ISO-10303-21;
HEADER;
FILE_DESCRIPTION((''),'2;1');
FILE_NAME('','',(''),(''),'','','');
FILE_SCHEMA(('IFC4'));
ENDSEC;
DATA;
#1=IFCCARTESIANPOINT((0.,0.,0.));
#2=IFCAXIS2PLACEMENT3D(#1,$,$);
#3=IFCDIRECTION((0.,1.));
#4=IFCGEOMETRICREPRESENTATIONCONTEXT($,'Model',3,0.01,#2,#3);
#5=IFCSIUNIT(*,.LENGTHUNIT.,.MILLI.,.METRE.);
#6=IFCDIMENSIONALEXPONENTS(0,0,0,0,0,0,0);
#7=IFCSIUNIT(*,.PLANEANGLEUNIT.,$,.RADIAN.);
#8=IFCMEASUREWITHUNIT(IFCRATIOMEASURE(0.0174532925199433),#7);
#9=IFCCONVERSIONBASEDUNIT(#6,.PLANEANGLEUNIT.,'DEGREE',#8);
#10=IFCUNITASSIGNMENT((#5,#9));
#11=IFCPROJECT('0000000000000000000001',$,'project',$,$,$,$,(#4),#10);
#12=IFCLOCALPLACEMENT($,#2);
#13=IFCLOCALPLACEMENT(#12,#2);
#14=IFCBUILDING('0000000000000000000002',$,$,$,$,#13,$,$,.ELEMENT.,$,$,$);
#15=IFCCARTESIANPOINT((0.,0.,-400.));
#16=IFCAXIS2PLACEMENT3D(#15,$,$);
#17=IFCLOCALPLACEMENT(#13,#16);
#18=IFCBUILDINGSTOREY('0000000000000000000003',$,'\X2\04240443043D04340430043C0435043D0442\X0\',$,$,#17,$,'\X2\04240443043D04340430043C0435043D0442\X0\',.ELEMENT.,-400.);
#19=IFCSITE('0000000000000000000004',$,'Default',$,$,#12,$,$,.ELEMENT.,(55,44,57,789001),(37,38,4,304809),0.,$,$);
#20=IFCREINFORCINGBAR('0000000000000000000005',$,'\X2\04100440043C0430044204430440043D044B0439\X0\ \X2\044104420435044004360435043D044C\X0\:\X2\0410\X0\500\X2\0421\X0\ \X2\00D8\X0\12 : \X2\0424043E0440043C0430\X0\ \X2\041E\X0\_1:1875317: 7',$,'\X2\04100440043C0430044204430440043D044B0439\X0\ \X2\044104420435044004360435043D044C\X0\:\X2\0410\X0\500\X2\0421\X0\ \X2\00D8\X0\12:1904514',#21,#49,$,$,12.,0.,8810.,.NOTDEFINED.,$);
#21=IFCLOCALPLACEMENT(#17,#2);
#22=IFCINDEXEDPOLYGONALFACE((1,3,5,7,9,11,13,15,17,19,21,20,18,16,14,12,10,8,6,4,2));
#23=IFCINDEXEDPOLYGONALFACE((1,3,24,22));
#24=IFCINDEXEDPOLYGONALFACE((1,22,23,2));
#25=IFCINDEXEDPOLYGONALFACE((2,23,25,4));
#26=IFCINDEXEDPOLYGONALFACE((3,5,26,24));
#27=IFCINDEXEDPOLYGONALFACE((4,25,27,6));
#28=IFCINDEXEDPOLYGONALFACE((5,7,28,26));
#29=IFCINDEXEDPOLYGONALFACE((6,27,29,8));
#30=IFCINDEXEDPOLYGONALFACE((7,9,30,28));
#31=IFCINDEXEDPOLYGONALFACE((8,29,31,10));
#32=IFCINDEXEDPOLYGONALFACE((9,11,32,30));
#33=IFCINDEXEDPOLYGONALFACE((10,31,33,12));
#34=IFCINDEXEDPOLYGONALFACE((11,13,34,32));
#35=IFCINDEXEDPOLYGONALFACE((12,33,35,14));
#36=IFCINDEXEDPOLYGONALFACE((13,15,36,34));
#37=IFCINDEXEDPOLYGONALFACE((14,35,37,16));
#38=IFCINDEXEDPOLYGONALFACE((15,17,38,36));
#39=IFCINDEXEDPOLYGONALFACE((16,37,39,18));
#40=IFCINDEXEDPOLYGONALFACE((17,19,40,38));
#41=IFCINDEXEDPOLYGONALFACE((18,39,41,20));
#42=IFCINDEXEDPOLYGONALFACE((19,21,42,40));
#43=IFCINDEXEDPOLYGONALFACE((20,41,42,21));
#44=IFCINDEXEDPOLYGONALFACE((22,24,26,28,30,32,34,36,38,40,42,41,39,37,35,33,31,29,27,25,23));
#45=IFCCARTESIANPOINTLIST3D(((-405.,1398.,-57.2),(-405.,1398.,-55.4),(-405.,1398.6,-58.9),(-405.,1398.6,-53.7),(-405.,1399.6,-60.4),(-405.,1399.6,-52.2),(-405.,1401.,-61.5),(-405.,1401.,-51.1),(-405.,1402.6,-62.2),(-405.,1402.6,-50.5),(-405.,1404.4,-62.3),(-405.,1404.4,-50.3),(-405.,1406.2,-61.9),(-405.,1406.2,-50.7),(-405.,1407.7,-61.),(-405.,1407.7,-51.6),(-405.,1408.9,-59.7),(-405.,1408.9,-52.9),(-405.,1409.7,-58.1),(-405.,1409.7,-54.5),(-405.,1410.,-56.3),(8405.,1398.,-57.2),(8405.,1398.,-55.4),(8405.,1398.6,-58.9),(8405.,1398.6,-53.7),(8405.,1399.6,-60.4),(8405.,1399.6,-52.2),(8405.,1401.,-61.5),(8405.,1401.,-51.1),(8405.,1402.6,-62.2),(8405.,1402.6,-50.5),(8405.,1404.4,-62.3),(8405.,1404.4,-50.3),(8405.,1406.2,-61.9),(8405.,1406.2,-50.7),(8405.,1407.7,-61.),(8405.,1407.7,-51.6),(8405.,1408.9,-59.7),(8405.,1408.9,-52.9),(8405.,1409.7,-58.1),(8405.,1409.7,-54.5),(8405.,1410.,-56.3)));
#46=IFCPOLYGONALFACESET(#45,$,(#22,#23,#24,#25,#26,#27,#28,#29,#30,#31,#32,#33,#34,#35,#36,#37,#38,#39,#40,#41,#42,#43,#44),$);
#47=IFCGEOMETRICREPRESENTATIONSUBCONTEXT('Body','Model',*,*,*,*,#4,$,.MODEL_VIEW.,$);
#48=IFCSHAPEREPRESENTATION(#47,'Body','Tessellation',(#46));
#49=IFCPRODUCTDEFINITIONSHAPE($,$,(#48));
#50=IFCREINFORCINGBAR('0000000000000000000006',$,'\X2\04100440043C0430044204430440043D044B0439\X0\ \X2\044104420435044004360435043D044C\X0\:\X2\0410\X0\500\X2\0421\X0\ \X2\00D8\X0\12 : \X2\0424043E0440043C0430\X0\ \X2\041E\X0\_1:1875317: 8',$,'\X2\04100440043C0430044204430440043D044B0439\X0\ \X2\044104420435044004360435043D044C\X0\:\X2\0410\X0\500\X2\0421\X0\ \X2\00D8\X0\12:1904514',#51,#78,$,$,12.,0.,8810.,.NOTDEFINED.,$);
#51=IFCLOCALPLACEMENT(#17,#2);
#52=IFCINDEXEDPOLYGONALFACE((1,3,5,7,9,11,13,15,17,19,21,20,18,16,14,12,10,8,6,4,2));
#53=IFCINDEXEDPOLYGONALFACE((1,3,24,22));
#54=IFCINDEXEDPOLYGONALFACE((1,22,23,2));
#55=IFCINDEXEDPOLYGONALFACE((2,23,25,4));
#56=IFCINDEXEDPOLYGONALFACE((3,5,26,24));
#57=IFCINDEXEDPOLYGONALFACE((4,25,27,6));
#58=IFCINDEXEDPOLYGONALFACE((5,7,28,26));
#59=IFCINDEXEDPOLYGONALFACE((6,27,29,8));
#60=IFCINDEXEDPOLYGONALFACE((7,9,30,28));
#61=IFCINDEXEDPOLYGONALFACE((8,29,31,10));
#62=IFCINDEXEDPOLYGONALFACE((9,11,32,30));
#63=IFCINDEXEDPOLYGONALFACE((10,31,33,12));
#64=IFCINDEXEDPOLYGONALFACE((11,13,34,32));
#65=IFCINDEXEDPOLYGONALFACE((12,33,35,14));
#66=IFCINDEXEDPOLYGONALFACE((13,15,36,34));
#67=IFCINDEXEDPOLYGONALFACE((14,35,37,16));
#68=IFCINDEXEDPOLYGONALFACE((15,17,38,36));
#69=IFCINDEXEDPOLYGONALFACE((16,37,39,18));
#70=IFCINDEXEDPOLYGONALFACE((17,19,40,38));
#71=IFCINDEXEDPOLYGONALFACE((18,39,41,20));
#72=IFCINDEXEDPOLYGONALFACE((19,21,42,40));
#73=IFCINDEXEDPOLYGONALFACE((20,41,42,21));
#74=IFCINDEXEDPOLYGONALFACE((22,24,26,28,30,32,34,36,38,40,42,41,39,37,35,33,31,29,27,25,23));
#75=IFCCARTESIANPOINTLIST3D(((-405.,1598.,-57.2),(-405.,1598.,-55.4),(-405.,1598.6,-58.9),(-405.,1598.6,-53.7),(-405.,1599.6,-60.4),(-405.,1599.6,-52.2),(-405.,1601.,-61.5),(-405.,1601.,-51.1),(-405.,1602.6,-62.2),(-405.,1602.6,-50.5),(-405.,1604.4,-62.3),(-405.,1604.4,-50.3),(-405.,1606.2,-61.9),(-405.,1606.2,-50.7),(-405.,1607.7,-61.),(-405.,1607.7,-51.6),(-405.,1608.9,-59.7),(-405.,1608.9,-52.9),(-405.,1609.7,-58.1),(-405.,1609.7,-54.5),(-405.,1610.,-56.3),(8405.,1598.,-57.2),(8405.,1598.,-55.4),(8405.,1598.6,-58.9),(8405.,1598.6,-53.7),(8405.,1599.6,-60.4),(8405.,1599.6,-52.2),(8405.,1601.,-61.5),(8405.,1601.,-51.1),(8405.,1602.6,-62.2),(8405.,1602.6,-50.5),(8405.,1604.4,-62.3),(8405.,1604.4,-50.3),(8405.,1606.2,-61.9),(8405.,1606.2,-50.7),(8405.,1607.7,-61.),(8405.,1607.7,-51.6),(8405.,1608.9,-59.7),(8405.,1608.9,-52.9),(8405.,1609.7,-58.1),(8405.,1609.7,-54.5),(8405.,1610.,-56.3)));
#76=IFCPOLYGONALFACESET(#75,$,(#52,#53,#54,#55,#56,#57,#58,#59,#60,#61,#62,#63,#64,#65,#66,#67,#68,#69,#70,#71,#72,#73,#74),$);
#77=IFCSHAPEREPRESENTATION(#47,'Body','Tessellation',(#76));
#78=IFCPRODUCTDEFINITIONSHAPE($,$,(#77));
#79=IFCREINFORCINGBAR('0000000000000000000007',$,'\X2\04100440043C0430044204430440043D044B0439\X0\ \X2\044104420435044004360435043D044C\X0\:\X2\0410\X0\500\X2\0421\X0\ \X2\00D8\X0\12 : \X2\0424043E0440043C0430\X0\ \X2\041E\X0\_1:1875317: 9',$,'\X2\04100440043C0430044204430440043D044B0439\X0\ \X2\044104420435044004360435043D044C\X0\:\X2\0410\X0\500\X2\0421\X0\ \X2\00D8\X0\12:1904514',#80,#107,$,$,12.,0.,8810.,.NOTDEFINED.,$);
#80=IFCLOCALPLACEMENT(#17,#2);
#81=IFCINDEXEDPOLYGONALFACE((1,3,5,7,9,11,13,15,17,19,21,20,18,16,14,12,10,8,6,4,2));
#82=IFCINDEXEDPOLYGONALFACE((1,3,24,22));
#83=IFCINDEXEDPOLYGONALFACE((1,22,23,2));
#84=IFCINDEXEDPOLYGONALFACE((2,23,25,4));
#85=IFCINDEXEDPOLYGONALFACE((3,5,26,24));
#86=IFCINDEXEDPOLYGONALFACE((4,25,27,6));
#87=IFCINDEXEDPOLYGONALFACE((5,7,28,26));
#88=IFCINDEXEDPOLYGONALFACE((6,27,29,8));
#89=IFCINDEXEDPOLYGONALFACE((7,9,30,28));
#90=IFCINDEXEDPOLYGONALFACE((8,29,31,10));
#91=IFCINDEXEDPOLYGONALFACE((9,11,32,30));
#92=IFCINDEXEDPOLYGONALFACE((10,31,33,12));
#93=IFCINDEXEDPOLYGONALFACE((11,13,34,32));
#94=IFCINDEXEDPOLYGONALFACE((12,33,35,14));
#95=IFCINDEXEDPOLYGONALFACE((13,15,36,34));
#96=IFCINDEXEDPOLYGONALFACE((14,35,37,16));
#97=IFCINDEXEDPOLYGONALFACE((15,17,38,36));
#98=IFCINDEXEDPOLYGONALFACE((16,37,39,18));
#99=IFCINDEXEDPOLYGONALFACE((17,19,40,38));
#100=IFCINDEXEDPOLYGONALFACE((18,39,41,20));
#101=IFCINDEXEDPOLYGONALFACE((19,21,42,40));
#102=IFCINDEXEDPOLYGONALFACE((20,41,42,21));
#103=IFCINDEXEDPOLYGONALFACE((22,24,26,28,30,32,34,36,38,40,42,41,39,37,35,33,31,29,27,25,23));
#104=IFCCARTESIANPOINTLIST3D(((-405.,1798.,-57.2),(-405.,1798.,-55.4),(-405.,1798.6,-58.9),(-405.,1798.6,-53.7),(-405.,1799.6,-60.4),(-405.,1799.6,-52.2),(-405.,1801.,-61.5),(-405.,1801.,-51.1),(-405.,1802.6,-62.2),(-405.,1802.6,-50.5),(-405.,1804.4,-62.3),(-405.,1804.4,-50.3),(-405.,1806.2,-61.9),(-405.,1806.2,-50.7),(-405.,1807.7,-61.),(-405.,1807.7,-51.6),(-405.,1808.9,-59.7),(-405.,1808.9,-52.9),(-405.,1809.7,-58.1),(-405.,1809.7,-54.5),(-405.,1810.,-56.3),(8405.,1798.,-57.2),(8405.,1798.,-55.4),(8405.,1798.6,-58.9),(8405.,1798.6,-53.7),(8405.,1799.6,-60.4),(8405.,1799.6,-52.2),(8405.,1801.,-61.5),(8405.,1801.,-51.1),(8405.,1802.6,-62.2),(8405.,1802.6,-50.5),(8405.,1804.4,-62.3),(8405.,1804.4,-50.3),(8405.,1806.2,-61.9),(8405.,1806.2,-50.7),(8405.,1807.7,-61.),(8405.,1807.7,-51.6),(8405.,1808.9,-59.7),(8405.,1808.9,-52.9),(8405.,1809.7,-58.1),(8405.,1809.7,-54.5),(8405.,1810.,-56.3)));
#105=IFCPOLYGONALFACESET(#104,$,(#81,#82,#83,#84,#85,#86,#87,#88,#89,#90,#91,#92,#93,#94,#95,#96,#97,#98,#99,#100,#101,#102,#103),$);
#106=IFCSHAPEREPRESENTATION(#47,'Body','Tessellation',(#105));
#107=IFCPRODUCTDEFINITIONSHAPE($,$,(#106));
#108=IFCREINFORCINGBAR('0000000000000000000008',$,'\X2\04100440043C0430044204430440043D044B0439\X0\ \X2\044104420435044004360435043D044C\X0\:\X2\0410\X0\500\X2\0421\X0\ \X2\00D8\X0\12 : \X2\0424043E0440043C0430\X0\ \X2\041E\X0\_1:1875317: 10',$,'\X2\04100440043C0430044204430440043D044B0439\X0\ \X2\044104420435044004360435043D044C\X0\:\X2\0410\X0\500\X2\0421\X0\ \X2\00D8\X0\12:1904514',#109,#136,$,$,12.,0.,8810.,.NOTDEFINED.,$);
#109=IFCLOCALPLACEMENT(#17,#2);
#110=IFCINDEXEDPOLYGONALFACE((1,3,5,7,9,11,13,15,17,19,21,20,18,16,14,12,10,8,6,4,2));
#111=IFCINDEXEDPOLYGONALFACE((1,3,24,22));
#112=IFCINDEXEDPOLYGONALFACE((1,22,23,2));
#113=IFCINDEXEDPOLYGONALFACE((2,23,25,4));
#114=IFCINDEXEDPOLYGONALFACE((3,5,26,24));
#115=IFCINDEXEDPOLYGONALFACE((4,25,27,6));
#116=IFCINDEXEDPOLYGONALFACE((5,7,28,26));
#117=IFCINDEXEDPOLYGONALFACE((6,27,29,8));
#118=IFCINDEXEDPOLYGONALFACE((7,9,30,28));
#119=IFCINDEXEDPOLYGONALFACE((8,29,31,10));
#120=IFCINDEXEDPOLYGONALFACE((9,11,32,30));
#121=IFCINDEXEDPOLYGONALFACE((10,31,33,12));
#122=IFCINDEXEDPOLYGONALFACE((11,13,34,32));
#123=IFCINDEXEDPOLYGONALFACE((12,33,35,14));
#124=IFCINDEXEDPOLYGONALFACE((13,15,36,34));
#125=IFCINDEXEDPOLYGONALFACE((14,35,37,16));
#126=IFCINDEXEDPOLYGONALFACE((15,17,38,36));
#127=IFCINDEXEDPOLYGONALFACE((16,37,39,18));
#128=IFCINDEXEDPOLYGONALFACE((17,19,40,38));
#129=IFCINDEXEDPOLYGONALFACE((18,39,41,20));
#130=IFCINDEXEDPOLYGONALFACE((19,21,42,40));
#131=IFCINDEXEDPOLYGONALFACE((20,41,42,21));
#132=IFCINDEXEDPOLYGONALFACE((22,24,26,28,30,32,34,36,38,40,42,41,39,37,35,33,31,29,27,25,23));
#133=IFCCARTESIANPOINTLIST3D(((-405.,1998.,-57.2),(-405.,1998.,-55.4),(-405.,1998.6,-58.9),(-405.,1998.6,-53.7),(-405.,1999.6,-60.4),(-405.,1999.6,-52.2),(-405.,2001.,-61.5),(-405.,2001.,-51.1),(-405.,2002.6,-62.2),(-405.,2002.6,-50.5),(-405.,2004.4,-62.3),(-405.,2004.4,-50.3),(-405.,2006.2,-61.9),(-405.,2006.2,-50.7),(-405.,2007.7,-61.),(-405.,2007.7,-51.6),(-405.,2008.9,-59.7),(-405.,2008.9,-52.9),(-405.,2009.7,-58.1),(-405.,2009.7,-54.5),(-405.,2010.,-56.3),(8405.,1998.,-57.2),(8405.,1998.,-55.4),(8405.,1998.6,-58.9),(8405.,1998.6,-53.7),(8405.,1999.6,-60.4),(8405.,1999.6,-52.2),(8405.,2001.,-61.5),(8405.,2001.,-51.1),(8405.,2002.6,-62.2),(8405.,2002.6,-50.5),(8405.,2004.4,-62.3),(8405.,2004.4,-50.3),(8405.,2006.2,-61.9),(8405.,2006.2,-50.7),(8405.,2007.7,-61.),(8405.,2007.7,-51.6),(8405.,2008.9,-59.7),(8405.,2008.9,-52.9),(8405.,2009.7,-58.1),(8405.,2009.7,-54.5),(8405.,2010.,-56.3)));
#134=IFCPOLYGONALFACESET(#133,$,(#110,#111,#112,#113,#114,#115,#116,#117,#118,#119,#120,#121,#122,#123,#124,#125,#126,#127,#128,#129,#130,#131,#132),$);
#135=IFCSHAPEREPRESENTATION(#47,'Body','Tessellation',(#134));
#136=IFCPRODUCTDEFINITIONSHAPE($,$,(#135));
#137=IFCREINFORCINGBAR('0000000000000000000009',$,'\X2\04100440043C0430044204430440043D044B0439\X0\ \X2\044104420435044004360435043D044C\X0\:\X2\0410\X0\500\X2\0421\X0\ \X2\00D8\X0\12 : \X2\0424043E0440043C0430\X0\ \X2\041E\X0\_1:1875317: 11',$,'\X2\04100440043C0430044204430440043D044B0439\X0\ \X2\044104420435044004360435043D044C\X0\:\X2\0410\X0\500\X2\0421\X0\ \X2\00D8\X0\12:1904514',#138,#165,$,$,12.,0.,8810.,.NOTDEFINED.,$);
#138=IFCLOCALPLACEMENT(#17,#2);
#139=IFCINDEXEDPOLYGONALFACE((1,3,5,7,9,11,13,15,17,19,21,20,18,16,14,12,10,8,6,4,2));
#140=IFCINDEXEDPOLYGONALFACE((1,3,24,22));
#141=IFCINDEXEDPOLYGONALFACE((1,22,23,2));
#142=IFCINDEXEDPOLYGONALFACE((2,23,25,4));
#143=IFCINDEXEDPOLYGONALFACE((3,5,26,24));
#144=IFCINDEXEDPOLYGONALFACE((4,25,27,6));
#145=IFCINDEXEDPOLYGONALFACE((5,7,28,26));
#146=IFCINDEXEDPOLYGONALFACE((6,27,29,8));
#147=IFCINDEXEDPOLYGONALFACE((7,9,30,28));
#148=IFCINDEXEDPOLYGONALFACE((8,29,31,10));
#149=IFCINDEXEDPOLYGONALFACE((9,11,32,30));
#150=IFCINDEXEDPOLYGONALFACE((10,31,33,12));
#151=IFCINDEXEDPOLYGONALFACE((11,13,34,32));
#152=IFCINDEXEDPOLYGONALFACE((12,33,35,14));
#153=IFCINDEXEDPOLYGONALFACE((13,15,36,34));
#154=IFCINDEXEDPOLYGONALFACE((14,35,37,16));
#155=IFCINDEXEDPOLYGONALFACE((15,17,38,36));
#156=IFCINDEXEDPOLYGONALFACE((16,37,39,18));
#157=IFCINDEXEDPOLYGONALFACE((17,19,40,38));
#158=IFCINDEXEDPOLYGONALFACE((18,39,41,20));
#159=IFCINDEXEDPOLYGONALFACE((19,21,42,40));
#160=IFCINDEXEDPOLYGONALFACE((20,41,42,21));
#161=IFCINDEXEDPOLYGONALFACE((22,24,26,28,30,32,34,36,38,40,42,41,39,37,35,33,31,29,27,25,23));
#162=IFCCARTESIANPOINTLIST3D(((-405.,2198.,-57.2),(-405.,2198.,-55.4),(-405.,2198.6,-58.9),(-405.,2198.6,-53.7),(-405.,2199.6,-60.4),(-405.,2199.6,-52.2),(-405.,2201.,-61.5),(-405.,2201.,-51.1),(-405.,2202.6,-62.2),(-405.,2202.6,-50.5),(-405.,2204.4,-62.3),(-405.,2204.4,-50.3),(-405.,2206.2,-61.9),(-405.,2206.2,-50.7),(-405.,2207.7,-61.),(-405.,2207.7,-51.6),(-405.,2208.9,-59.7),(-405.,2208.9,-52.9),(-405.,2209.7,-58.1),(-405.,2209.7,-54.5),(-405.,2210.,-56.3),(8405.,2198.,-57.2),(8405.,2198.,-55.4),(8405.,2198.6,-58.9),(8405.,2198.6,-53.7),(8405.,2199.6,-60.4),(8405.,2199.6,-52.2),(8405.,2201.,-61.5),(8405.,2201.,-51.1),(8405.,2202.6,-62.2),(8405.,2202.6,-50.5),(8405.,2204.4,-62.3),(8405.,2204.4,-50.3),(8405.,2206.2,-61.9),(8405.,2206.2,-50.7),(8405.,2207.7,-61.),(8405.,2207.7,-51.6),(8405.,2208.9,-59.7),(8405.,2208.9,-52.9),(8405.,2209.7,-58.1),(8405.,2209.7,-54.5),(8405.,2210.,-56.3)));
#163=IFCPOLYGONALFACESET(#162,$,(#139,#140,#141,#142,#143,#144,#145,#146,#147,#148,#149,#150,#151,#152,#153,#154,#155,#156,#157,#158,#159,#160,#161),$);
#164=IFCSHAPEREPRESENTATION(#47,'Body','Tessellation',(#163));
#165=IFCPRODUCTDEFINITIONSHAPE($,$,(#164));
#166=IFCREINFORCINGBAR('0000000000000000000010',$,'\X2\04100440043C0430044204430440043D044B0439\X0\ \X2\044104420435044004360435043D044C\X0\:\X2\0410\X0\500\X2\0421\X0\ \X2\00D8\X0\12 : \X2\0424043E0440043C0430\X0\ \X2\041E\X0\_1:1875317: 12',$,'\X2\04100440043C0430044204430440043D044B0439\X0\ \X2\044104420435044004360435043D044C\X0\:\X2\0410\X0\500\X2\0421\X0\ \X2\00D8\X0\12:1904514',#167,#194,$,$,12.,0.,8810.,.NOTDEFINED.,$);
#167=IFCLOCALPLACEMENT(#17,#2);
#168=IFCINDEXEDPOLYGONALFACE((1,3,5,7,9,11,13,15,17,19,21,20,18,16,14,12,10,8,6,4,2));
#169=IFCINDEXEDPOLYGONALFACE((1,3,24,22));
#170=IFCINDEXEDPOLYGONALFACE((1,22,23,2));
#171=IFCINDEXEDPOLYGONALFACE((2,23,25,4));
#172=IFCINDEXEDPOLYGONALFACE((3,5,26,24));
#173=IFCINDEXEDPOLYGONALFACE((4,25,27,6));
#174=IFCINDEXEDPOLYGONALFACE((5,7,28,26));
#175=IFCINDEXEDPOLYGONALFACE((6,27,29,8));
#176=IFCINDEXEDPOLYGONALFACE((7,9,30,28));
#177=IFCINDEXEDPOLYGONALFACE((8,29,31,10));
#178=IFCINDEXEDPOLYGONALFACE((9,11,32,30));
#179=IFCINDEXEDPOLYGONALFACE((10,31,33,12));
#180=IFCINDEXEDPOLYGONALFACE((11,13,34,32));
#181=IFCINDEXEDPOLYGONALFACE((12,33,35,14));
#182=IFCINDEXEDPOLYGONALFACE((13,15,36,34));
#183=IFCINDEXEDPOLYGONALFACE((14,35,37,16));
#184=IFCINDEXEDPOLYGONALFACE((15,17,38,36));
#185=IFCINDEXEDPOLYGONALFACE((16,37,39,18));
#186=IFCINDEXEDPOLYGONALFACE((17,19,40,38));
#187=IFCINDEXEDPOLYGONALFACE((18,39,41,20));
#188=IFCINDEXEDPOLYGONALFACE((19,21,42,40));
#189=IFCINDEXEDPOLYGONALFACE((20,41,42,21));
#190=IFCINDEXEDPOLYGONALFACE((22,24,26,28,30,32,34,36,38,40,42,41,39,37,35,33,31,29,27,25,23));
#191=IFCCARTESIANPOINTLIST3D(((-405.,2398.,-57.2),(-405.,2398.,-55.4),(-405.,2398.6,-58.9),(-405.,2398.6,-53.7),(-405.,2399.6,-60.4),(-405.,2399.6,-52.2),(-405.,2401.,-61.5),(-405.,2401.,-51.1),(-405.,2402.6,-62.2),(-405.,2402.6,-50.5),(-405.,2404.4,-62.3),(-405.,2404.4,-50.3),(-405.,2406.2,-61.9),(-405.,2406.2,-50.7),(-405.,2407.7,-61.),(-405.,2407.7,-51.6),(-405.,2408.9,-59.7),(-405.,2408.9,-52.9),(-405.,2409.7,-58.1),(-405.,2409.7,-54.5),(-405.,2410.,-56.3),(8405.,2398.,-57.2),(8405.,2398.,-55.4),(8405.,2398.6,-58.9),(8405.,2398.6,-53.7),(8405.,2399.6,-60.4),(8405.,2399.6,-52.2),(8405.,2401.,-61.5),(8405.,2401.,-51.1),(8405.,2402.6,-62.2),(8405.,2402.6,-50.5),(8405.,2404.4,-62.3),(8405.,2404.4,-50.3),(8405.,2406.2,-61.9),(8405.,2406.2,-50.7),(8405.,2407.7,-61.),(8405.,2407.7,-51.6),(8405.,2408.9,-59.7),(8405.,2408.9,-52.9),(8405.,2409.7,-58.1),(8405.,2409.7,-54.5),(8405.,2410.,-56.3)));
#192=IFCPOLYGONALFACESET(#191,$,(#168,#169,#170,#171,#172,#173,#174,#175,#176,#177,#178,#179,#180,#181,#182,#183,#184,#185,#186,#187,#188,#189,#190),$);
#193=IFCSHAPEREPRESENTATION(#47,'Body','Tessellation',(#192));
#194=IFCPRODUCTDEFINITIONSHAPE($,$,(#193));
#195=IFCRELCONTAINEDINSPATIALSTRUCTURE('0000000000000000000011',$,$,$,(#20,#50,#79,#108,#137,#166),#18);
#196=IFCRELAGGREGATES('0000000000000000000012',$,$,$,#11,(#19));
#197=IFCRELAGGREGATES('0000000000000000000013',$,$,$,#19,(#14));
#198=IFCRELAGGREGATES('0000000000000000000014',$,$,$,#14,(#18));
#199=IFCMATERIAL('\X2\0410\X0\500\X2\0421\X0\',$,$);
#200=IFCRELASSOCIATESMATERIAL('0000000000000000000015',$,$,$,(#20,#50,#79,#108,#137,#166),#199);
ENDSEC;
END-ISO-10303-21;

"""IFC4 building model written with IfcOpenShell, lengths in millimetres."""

from ifc_helpers import new_model, entity, si_unit, converted_unit, direction, frame, origin, place, context, subcontext, project, spatial, material, element, save


model = new_model("IFC4")

# Units and contexts
model_context = context("Model", 3, precision=0.01, world=origin(), true_north=direction((0.0, 1.0)))
body_context = subcontext(model_context, "Body", "Model", "MODEL_VIEW")
ifc_project = project(units=[si_unit("LENGTHUNIT", "METRE", prefix="MILLI"), converted_unit("PLANEANGLEUNIT", "DEGREE", entity("IfcRatioMeasure", 0.0174532925199433), si_unit("PLANEANGLEUNIT", "RADIAN"), dimensions=[0, 0, 0, 0, 0, 0, 0])], contexts=[model_context])

# Site, building, storey
site_placement = place(None, origin())
site = spatial("IfcSite", under=ifc_project, at=site_placement, Name="Default", CompositionType="ELEMENT", RefLatitude=(55, 44, 57, 789001), RefLongitude=(37, 38, 4, 304809), RefElevation=0.0)
building_placement = place(site_placement, origin())
building = spatial("IfcBuilding", under=site, at=building_placement, CompositionType="ELEMENT")
storey_placement = place(building_placement, frame((0.0, 0.0, -400.0)))
storey = spatial("IfcBuildingStorey", under=building, at=storey_placement, Name="Фундамент", LongName="Фундамент", CompositionType="ELEMENT", Elevation=-400.0)

# Reinforcing bars
ifc_material = material(Name="А500С")
reinforcing_bar_1_placement = place(storey_placement, origin())
element("IfcReinforcingBar", 1, at=reinforcing_bar_1_placement, inside=storey, material=ifc_material, Name="Арматурный стержень:А500С Ø12 : Форма О_1:1875317: 7", ObjectType="Арматурный стержень:А500С Ø12:1904514", BarLength=8810.0, CrossSectionArea=0.0, NominalDiameter=12.0, PredefinedType="NOTDEFINED", context=body_context, shape_type="AdvancedSweptSolid", body=[
    entity("IfcSweptDiskSolid", entity("IfcCompositeCurve", [entity("IfcCompositeCurveSegment", "CONTINUOUS", True, entity("IfcPolyline", [entity("IfcCartesianPoint", [-405.0, 1404.0, -56.3]), entity("IfcCartesianPoint", [8405.0, 1404.0, -56.3])]))], False), 6.0, None, 0.0, 1.0),
])
reinforcing_bar_2_placement = place(storey_placement, origin())
element("IfcReinforcingBar", 2, at=reinforcing_bar_2_placement, inside=storey, material=ifc_material, Name="Арматурный стержень:А500С Ø12 : Форма О_1:1875317: 8", ObjectType="Арматурный стержень:А500С Ø12:1904514", BarLength=8810.0, CrossSectionArea=0.0, NominalDiameter=12.0, PredefinedType="NOTDEFINED", context=body_context, shape_type="AdvancedSweptSolid", body=[
    entity("IfcSweptDiskSolid", entity("IfcCompositeCurve", [entity("IfcCompositeCurveSegment", "CONTINUOUS", True, entity("IfcPolyline", [entity("IfcCartesianPoint", [-405.0, 1604.0, -56.3]), entity("IfcCartesianPoint", [8405.0, 1604.0, -56.3])]))], False), 6.0, None, 0.0, 1.0),
])
reinforcing_bar_3_placement = place(storey_placement, origin())
element("IfcReinforcingBar", 3, at=reinforcing_bar_3_placement, inside=storey, material=ifc_material, Name="Арматурный стержень:А500С Ø12 : Форма О_1:1875317: 9", ObjectType="Арматурный стержень:А500С Ø12:1904514", BarLength=8810.0, CrossSectionArea=0.0, NominalDiameter=12.0, PredefinedType="NOTDEFINED", context=body_context, shape_type="AdvancedSweptSolid", body=[
    entity("IfcSweptDiskSolid", entity("IfcCompositeCurve", [entity("IfcCompositeCurveSegment", "CONTINUOUS", True, entity("IfcPolyline", [entity("IfcCartesianPoint", [-405.0, 1804.0, -56.3]), entity("IfcCartesianPoint", [8405.0, 1804.0, -56.3])]))], False), 6.0, None, 0.0, 1.0),
])
reinforcing_bar_4_placement = place(storey_placement, origin())
element("IfcReinforcingBar", 4, at=reinforcing_bar_4_placement, inside=storey, material=ifc_material, Name="Арматурный стержень:А500С Ø12 : Форма О_1:1875317: 10", ObjectType="Арматурный стержень:А500С Ø12:1904514", BarLength=8810.0, CrossSectionArea=0.0, NominalDiameter=12.0, PredefinedType="NOTDEFINED", context=body_context, shape_type="AdvancedSweptSolid", body=[
    entity("IfcSweptDiskSolid", entity("IfcCompositeCurve", [entity("IfcCompositeCurveSegment", "CONTINUOUS", True, entity("IfcPolyline", [entity("IfcCartesianPoint", [-405.0, 2004.0, -56.3]), entity("IfcCartesianPoint", [8405.0, 2004.0, -56.3])]))], False), 6.0, None, 0.0, 1.0),
])
reinforcing_bar_5_placement = place(storey_placement, origin())
element("IfcReinforcingBar", 5, at=reinforcing_bar_5_placement, inside=storey, material=ifc_material, Name="Арматурный стержень:А500С Ø12 : Форма О_1:1875317: 11", ObjectType="Арматурный стержень:А500С Ø12:1904514", BarLength=8810.0, CrossSectionArea=0.0, NominalDiameter=12.0, PredefinedType="NOTDEFINED", context=body_context, shape_type="AdvancedSweptSolid", body=[
    entity("IfcSweptDiskSolid", entity("IfcCompositeCurve", [entity("IfcCompositeCurveSegment", "CONTINUOUS", True, entity("IfcPolyline", [entity("IfcCartesianPoint", [-405.0, 2204.0, -56.3]), entity("IfcCartesianPoint", [8405.0, 2204.0, -56.3])]))], False), 6.0, None, 0.0, 1.0),
])
reinforcing_bar_6_placement = place(storey_placement, origin())
element("IfcReinforcingBar", 6, at=reinforcing_bar_6_placement, inside=storey, material=ifc_material, Name="Арматурный стержень:А500С Ø12 : Форма О_1:1875317: 12", ObjectType="Арматурный стержень:А500С Ø12:1904514", BarLength=8810.0, CrossSectionArea=0.0, NominalDiameter=12.0, PredefinedType="NOTDEFINED", context=body_context, shape_type="AdvancedSweptSolid", body=[
    entity("IfcSweptDiskSolid", entity("IfcCompositeCurve", [entity("IfcCompositeCurveSegment", "CONTINUOUS", True, entity("IfcPolyline", [entity("IfcCartesianPoint", [-405.0, 2404.0, -56.3]), entity("IfcCartesianPoint", [8405.0, 2404.0, -56.3])]))], False), 6.0, None, 0.0, 1.0),
])

save(model, "model.ifc")
